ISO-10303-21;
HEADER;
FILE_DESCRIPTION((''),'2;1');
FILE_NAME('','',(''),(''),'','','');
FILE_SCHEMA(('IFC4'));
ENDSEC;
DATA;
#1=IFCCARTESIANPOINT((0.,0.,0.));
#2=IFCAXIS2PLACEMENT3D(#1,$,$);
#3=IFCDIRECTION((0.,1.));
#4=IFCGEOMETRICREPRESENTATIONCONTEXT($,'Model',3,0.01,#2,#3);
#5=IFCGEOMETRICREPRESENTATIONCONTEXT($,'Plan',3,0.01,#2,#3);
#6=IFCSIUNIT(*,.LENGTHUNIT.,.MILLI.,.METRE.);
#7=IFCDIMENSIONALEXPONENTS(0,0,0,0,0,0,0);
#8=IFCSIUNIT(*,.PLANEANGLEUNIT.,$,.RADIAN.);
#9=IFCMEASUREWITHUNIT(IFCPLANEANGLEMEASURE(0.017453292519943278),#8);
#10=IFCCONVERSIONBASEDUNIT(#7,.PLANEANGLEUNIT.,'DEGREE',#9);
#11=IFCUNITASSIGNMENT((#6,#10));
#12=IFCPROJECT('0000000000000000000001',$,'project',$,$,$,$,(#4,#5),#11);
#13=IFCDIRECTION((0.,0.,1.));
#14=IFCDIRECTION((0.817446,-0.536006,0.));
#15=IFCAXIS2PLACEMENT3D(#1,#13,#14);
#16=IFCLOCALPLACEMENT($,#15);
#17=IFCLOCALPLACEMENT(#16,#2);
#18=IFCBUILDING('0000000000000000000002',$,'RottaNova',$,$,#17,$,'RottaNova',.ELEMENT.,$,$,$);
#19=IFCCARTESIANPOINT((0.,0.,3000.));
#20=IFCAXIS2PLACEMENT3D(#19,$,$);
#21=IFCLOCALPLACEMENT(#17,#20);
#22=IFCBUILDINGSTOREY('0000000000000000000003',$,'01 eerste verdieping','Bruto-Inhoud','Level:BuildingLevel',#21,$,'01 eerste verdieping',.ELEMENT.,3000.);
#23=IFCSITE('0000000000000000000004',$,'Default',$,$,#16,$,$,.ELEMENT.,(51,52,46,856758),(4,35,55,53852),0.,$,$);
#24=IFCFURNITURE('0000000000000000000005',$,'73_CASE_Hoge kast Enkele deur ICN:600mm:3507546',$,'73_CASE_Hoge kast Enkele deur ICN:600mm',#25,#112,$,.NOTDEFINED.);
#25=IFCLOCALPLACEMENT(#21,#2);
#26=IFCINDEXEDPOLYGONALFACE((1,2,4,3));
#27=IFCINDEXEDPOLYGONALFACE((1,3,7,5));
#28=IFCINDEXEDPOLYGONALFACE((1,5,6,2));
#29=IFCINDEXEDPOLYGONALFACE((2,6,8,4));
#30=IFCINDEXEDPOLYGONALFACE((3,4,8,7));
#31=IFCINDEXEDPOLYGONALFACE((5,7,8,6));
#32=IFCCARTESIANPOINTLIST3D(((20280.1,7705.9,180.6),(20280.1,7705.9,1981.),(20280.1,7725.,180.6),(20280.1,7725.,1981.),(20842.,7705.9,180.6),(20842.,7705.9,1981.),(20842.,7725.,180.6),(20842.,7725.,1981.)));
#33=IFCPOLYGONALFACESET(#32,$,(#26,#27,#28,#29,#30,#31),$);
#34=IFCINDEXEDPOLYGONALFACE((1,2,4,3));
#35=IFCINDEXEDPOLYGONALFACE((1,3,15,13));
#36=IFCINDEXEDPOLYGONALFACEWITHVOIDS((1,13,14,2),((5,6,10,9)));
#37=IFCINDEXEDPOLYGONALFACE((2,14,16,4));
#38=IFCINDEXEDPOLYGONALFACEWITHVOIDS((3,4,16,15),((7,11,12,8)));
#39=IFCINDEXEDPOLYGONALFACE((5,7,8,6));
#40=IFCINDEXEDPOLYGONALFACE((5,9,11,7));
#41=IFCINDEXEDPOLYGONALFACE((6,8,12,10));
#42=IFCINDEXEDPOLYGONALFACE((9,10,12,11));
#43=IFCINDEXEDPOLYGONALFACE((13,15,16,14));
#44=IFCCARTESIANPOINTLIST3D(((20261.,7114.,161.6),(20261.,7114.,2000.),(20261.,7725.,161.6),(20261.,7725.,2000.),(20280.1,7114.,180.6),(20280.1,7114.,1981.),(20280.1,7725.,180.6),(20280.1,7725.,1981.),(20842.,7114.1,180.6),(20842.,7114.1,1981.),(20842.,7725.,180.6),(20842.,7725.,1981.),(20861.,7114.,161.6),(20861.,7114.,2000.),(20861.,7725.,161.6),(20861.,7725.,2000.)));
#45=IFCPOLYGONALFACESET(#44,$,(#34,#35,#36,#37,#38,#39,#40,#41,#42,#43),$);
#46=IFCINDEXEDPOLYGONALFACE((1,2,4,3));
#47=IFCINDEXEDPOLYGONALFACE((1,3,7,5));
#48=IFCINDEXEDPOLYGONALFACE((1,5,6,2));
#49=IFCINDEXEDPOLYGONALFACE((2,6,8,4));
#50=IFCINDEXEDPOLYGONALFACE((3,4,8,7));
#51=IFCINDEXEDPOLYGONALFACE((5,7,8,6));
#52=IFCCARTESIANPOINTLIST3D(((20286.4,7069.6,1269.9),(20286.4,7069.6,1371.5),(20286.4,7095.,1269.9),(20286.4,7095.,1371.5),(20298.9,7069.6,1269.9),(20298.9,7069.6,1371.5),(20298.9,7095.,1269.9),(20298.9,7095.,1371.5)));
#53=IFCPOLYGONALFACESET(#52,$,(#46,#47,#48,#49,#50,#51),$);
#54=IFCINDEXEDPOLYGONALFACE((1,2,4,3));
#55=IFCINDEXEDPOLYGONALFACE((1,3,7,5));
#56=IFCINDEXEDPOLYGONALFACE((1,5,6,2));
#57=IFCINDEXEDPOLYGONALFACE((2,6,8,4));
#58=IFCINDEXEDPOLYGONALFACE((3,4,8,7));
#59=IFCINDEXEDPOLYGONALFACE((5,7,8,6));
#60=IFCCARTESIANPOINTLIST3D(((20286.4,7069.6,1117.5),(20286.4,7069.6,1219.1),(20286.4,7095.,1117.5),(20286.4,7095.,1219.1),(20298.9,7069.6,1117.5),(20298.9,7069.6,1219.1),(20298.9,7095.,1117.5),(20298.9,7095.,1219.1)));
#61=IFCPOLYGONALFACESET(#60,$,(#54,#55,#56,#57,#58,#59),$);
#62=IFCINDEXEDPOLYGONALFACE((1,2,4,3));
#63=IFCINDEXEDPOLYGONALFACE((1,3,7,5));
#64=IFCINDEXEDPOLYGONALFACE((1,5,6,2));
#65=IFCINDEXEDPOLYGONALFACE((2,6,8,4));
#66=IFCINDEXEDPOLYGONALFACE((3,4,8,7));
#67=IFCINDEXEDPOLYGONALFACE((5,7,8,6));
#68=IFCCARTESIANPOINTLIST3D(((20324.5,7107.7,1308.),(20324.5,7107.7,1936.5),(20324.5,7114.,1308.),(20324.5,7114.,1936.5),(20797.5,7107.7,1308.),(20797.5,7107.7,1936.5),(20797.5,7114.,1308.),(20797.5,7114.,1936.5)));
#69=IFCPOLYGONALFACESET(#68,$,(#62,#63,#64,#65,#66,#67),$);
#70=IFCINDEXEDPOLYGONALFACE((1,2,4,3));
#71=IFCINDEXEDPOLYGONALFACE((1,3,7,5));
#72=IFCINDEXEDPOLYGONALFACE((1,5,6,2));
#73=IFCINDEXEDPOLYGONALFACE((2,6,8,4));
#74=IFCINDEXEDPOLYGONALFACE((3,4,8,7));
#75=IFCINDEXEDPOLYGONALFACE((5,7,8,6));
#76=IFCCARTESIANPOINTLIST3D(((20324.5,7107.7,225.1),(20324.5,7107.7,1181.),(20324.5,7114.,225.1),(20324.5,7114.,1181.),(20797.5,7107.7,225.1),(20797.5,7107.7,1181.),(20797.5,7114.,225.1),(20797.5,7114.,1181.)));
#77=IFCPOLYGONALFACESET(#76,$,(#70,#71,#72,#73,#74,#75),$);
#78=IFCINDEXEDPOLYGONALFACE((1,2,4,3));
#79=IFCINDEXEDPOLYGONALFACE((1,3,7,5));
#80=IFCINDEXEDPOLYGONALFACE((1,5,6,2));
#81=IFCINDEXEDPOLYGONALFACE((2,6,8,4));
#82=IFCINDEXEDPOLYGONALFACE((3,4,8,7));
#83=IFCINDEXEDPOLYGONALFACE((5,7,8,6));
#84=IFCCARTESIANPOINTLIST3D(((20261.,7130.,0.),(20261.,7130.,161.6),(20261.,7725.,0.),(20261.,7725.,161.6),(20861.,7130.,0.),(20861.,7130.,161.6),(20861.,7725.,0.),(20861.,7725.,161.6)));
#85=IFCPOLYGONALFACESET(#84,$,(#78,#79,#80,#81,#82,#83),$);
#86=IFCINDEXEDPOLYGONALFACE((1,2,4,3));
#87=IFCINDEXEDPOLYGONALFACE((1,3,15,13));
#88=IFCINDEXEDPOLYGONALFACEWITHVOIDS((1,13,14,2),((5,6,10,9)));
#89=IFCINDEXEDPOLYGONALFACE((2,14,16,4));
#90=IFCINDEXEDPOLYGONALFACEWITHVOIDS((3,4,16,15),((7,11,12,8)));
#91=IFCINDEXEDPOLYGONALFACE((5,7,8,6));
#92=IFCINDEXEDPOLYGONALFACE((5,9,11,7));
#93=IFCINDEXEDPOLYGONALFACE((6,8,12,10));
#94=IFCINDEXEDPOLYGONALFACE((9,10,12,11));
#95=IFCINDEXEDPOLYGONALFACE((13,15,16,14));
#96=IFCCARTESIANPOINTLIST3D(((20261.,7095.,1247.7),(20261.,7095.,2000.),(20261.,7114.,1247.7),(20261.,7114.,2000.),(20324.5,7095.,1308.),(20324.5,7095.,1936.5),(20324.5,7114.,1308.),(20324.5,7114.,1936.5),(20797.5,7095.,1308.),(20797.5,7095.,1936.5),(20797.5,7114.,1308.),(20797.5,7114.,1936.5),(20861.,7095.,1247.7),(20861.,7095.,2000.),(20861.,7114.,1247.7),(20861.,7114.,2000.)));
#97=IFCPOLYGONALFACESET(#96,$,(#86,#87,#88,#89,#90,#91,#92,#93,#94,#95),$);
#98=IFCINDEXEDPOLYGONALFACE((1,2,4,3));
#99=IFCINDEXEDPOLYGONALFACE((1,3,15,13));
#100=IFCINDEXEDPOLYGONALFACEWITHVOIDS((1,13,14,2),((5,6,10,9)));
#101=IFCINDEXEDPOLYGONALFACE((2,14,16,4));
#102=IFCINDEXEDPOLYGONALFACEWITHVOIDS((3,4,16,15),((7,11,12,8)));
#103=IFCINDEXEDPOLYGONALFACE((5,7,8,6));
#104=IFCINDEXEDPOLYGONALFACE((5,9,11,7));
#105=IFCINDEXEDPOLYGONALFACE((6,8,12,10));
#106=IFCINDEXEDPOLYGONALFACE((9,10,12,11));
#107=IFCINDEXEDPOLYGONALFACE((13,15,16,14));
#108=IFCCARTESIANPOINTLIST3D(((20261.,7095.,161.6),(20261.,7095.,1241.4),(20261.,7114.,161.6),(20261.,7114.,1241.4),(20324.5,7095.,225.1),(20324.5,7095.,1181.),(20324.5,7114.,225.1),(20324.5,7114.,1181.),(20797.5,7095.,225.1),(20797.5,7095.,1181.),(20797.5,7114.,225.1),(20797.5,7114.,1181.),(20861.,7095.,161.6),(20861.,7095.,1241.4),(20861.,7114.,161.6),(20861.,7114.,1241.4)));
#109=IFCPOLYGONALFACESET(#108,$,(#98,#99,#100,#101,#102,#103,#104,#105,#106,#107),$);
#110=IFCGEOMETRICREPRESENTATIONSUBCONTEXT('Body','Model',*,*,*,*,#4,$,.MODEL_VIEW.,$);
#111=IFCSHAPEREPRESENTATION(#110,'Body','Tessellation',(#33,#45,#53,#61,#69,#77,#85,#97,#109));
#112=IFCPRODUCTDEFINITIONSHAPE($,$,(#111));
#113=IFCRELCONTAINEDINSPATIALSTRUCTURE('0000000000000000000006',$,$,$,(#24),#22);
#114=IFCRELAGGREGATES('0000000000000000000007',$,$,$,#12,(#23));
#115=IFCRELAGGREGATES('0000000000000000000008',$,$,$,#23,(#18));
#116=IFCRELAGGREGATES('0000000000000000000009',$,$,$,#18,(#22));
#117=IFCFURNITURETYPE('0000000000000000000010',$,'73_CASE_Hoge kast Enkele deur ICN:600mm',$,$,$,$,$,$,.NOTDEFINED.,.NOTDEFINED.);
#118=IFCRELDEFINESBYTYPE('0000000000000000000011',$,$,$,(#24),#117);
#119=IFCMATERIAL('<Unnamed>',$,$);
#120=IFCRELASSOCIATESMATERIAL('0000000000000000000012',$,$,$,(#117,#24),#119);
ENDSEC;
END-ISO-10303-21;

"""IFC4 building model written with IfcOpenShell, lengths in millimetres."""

from ifc_helpers import new_model, entity, si_unit, converted_unit, direction, frame, origin, place, context, subcontext, project, spatial, indexed_curve, outline, extrude, source, transform, mapped, material, type_object, type_shapes, element, save


model = new_model("IFC4")

# Units and contexts
model_context = context("Model", 3, precision=0.01, world=origin(), true_north=direction((0.0, 1.0)))
plan_context = context("Plan", 3, precision=0.01, world=origin(), true_north=direction((0.0, 1.0)))
body_context = subcontext(model_context, "Body", "Model", "MODEL_VIEW")
ifc_project = project(units=[si_unit("LENGTHUNIT", "METRE", prefix="MILLI"), converted_unit("PLANEANGLEUNIT", "DEGREE", entity("IfcPlaneAngleMeasure", 0.017453292519943278), si_unit("PLANEANGLEUNIT", "RADIAN"), dimensions=[0, 0, 0, 0, 0, 0, 0])], contexts=[model_context, plan_context])

# Site, building, storey
site_placement = place(None, frame((0.0, 0.0, 0.0), z_axis=(0.0, 0.0, 1.0), x_axis=(0.817446, -0.536006, 0.0)))
site = spatial("IfcSite", under=ifc_project, at=site_placement, Name="Default", CompositionType="ELEMENT", RefLatitude=(51, 52, 46, 856758), RefLongitude=(4, 35, 55, 53852), RefElevation=0.0)
building_placement = place(site_placement, origin())
building = spatial("IfcBuilding", under=site, at=building_placement, Name="RottaNova", LongName="RottaNova", CompositionType="ELEMENT")
storey_placement = place(building_placement, frame((0.0, 0.0, 3000.0)))
storey = spatial("IfcBuildingStorey", under=building, at=storey_placement, Name="01 eerste verdieping", Description="Bruto-Inhoud", ObjectType="Level:BuildingLevel", LongName="01 eerste verdieping", CompositionType="ELEMENT", Elevation=3000.0)

# Furniture
ifc_material_1 = material(Name="<Unnamed>")
furniture_type = type_object("IfcFurnitureType", Name="73_CASE_Hoge kast Enkele deur ICN:600mm", AssemblyPlace="NOTDEFINED", PredefinedType="NOTDEFINED", material=ifc_material_1)
shared_shape_1 = source(origin(), body_context, "Body", "SweptSolid", [
    extrude(outline(indexed_curve([(-280.9, -9.5), (280.9, -9.5), (280.9, 9.5), (-280.9, 9.5), (-280.9, -9.5)], self_intersect=False)), frame((18.7, 9.5, 180.6), z_axis=(0.0, 0.0, 1.0), x_axis=(-1.0, 0.0, 0.0)), (0.0, 0.0, 1.0), 1800.3),
    extrude(outline(indexed_curve([(-300.0, -919.2), (300.0, -919.2), (300.0, 919.2), (-300.0, 919.2), (-300.0, -919.2)], self_intersect=False), holes=[indexed_curve([(-280.9, 900.2), (281.0, 900.2), (281.0, -900.2), (-280.9, -900.2), (-280.9, 900.2)], self_intersect=False)]), frame((18.7, 0.0, 1080.8), z_axis=(0.0, 1.0, 0.0), x_axis=(-1.0, 0.0, 0.0)), (0.0, 0.0, 1.0), 610.9),
    extrude(outline(indexed_curve([(-6.3, -12.7), (6.3, -12.7), (6.3, 12.7), (-6.3, 12.7), (-6.3, -12.7)], self_intersect=False)), frame((287.1, 642.7, 1269.9), z_axis=(0.0, 0.0, 1.0), x_axis=(-1.0, 0.0, 0.0)), (0.0, 0.0, 1.0), 101.6),
    extrude(outline(indexed_curve([(-6.3, -12.7), (6.3, -12.7), (6.3, 12.7), (-6.3, 12.7), (-6.3, -12.7)], self_intersect=False)), frame((287.1, 642.7, 1117.5), z_axis=(0.0, 0.0, 1.0), x_axis=(-1.0, 0.0, 0.0)), (0.0, 0.0, 1.0), 101.6),
    extrude(outline(indexed_curve([(-236.5, -3.2), (236.5, -3.2), (236.5, 3.2), (-236.5, 3.2), (-236.5, -3.2)], self_intersect=False)), frame((18.7, 614.1, 1308.0), z_axis=(0.0, 0.0, 1.0), x_axis=(-1.0, 0.0, 0.0)), (0.0, 0.0, 1.0), 628.5),
    extrude(outline(indexed_curve([(-236.5, -3.2), (236.5, -3.2), (236.5, 3.2), (-236.5, 3.2), (-236.5, -3.2)], self_intersect=False)), frame((18.7, 614.1, 225.1), z_axis=(0.0, 0.0, 1.0), x_axis=(-1.0, 0.0, 0.0)), (0.0, 0.0, 1.0), 956.0),
    extrude(outline(indexed_curve([(-297.5, -300.0), (297.5, -300.0), (297.5, 300.0), (-297.5, 300.0), (-297.5, -300.0)], self_intersect=False)), frame((18.7, 297.5, 0.0), z_axis=(0.0, 0.0, 1.0), x_axis=(0.0, 1.0, 0.0)), (0.0, 0.0, 1.0), 161.6),
    extrude(outline(indexed_curve([(-376.1, -300.0), (376.1, -300.0), (376.1, 300.0), (-376.1, 300.0), (-376.1, -300.0)], self_intersect=False), holes=[indexed_curve([(-312.6, -236.5), (-312.6, 236.5), (315.8, 236.5), (315.8, -236.5), (-312.6, -236.5)], self_intersect=False)]), frame((18.7, 610.9, 1623.9), z_axis=(0.0, 1.0, 0.0), x_axis=(0.0, 0.0, -1.0)), (0.0, 0.0, 1.0), 19.1),
    extrude(outline(indexed_curve([(-300.0, -539.9), (300.0, -539.9), (300.0, 539.9), (-300.0, 539.9), (-300.0, -539.9)], self_intersect=False), holes=[indexed_curve([(-236.5, 479.6), (236.5, 479.6), (236.5, -476.4), (-236.5, -476.4), (-236.5, 479.6)], self_intersect=False)]), frame((18.7, 610.9, 701.5), z_axis=(0.0, 1.0, 0.0), x_axis=(-1.0, 0.0, 0.0)), (0.0, 0.0, 1.0), 19.1),
])
type_shapes(furniture_type, [shared_shape_1])
for number, where, z_axis, x_axis, name in (
    (1, (20579.7, 7725.0, 0.0), (0.0, 0.0, 1.0), (-1.0, 0.0, 0.0), "73_CASE_Hoge kast Enkele deur ICN:600mm:3507546"),
):
    element("IfcFurniture", number, at=place(storey_placement, frame(where, z_axis=z_axis, x_axis=x_axis)), inside=storey, type_object=furniture_type, material=ifc_material_1, Name=name, ObjectType="73_CASE_Hoge kast Enkele deur ICN:600mm", PredefinedType="NOTDEFINED", context=body_context, shape_type="MappedRepresentation", body=[
        mapped(shared_shape_1, transform((0.0, 0.0, 0.0), scale=1.0)),
    ])

save(model, "model.ifc")
